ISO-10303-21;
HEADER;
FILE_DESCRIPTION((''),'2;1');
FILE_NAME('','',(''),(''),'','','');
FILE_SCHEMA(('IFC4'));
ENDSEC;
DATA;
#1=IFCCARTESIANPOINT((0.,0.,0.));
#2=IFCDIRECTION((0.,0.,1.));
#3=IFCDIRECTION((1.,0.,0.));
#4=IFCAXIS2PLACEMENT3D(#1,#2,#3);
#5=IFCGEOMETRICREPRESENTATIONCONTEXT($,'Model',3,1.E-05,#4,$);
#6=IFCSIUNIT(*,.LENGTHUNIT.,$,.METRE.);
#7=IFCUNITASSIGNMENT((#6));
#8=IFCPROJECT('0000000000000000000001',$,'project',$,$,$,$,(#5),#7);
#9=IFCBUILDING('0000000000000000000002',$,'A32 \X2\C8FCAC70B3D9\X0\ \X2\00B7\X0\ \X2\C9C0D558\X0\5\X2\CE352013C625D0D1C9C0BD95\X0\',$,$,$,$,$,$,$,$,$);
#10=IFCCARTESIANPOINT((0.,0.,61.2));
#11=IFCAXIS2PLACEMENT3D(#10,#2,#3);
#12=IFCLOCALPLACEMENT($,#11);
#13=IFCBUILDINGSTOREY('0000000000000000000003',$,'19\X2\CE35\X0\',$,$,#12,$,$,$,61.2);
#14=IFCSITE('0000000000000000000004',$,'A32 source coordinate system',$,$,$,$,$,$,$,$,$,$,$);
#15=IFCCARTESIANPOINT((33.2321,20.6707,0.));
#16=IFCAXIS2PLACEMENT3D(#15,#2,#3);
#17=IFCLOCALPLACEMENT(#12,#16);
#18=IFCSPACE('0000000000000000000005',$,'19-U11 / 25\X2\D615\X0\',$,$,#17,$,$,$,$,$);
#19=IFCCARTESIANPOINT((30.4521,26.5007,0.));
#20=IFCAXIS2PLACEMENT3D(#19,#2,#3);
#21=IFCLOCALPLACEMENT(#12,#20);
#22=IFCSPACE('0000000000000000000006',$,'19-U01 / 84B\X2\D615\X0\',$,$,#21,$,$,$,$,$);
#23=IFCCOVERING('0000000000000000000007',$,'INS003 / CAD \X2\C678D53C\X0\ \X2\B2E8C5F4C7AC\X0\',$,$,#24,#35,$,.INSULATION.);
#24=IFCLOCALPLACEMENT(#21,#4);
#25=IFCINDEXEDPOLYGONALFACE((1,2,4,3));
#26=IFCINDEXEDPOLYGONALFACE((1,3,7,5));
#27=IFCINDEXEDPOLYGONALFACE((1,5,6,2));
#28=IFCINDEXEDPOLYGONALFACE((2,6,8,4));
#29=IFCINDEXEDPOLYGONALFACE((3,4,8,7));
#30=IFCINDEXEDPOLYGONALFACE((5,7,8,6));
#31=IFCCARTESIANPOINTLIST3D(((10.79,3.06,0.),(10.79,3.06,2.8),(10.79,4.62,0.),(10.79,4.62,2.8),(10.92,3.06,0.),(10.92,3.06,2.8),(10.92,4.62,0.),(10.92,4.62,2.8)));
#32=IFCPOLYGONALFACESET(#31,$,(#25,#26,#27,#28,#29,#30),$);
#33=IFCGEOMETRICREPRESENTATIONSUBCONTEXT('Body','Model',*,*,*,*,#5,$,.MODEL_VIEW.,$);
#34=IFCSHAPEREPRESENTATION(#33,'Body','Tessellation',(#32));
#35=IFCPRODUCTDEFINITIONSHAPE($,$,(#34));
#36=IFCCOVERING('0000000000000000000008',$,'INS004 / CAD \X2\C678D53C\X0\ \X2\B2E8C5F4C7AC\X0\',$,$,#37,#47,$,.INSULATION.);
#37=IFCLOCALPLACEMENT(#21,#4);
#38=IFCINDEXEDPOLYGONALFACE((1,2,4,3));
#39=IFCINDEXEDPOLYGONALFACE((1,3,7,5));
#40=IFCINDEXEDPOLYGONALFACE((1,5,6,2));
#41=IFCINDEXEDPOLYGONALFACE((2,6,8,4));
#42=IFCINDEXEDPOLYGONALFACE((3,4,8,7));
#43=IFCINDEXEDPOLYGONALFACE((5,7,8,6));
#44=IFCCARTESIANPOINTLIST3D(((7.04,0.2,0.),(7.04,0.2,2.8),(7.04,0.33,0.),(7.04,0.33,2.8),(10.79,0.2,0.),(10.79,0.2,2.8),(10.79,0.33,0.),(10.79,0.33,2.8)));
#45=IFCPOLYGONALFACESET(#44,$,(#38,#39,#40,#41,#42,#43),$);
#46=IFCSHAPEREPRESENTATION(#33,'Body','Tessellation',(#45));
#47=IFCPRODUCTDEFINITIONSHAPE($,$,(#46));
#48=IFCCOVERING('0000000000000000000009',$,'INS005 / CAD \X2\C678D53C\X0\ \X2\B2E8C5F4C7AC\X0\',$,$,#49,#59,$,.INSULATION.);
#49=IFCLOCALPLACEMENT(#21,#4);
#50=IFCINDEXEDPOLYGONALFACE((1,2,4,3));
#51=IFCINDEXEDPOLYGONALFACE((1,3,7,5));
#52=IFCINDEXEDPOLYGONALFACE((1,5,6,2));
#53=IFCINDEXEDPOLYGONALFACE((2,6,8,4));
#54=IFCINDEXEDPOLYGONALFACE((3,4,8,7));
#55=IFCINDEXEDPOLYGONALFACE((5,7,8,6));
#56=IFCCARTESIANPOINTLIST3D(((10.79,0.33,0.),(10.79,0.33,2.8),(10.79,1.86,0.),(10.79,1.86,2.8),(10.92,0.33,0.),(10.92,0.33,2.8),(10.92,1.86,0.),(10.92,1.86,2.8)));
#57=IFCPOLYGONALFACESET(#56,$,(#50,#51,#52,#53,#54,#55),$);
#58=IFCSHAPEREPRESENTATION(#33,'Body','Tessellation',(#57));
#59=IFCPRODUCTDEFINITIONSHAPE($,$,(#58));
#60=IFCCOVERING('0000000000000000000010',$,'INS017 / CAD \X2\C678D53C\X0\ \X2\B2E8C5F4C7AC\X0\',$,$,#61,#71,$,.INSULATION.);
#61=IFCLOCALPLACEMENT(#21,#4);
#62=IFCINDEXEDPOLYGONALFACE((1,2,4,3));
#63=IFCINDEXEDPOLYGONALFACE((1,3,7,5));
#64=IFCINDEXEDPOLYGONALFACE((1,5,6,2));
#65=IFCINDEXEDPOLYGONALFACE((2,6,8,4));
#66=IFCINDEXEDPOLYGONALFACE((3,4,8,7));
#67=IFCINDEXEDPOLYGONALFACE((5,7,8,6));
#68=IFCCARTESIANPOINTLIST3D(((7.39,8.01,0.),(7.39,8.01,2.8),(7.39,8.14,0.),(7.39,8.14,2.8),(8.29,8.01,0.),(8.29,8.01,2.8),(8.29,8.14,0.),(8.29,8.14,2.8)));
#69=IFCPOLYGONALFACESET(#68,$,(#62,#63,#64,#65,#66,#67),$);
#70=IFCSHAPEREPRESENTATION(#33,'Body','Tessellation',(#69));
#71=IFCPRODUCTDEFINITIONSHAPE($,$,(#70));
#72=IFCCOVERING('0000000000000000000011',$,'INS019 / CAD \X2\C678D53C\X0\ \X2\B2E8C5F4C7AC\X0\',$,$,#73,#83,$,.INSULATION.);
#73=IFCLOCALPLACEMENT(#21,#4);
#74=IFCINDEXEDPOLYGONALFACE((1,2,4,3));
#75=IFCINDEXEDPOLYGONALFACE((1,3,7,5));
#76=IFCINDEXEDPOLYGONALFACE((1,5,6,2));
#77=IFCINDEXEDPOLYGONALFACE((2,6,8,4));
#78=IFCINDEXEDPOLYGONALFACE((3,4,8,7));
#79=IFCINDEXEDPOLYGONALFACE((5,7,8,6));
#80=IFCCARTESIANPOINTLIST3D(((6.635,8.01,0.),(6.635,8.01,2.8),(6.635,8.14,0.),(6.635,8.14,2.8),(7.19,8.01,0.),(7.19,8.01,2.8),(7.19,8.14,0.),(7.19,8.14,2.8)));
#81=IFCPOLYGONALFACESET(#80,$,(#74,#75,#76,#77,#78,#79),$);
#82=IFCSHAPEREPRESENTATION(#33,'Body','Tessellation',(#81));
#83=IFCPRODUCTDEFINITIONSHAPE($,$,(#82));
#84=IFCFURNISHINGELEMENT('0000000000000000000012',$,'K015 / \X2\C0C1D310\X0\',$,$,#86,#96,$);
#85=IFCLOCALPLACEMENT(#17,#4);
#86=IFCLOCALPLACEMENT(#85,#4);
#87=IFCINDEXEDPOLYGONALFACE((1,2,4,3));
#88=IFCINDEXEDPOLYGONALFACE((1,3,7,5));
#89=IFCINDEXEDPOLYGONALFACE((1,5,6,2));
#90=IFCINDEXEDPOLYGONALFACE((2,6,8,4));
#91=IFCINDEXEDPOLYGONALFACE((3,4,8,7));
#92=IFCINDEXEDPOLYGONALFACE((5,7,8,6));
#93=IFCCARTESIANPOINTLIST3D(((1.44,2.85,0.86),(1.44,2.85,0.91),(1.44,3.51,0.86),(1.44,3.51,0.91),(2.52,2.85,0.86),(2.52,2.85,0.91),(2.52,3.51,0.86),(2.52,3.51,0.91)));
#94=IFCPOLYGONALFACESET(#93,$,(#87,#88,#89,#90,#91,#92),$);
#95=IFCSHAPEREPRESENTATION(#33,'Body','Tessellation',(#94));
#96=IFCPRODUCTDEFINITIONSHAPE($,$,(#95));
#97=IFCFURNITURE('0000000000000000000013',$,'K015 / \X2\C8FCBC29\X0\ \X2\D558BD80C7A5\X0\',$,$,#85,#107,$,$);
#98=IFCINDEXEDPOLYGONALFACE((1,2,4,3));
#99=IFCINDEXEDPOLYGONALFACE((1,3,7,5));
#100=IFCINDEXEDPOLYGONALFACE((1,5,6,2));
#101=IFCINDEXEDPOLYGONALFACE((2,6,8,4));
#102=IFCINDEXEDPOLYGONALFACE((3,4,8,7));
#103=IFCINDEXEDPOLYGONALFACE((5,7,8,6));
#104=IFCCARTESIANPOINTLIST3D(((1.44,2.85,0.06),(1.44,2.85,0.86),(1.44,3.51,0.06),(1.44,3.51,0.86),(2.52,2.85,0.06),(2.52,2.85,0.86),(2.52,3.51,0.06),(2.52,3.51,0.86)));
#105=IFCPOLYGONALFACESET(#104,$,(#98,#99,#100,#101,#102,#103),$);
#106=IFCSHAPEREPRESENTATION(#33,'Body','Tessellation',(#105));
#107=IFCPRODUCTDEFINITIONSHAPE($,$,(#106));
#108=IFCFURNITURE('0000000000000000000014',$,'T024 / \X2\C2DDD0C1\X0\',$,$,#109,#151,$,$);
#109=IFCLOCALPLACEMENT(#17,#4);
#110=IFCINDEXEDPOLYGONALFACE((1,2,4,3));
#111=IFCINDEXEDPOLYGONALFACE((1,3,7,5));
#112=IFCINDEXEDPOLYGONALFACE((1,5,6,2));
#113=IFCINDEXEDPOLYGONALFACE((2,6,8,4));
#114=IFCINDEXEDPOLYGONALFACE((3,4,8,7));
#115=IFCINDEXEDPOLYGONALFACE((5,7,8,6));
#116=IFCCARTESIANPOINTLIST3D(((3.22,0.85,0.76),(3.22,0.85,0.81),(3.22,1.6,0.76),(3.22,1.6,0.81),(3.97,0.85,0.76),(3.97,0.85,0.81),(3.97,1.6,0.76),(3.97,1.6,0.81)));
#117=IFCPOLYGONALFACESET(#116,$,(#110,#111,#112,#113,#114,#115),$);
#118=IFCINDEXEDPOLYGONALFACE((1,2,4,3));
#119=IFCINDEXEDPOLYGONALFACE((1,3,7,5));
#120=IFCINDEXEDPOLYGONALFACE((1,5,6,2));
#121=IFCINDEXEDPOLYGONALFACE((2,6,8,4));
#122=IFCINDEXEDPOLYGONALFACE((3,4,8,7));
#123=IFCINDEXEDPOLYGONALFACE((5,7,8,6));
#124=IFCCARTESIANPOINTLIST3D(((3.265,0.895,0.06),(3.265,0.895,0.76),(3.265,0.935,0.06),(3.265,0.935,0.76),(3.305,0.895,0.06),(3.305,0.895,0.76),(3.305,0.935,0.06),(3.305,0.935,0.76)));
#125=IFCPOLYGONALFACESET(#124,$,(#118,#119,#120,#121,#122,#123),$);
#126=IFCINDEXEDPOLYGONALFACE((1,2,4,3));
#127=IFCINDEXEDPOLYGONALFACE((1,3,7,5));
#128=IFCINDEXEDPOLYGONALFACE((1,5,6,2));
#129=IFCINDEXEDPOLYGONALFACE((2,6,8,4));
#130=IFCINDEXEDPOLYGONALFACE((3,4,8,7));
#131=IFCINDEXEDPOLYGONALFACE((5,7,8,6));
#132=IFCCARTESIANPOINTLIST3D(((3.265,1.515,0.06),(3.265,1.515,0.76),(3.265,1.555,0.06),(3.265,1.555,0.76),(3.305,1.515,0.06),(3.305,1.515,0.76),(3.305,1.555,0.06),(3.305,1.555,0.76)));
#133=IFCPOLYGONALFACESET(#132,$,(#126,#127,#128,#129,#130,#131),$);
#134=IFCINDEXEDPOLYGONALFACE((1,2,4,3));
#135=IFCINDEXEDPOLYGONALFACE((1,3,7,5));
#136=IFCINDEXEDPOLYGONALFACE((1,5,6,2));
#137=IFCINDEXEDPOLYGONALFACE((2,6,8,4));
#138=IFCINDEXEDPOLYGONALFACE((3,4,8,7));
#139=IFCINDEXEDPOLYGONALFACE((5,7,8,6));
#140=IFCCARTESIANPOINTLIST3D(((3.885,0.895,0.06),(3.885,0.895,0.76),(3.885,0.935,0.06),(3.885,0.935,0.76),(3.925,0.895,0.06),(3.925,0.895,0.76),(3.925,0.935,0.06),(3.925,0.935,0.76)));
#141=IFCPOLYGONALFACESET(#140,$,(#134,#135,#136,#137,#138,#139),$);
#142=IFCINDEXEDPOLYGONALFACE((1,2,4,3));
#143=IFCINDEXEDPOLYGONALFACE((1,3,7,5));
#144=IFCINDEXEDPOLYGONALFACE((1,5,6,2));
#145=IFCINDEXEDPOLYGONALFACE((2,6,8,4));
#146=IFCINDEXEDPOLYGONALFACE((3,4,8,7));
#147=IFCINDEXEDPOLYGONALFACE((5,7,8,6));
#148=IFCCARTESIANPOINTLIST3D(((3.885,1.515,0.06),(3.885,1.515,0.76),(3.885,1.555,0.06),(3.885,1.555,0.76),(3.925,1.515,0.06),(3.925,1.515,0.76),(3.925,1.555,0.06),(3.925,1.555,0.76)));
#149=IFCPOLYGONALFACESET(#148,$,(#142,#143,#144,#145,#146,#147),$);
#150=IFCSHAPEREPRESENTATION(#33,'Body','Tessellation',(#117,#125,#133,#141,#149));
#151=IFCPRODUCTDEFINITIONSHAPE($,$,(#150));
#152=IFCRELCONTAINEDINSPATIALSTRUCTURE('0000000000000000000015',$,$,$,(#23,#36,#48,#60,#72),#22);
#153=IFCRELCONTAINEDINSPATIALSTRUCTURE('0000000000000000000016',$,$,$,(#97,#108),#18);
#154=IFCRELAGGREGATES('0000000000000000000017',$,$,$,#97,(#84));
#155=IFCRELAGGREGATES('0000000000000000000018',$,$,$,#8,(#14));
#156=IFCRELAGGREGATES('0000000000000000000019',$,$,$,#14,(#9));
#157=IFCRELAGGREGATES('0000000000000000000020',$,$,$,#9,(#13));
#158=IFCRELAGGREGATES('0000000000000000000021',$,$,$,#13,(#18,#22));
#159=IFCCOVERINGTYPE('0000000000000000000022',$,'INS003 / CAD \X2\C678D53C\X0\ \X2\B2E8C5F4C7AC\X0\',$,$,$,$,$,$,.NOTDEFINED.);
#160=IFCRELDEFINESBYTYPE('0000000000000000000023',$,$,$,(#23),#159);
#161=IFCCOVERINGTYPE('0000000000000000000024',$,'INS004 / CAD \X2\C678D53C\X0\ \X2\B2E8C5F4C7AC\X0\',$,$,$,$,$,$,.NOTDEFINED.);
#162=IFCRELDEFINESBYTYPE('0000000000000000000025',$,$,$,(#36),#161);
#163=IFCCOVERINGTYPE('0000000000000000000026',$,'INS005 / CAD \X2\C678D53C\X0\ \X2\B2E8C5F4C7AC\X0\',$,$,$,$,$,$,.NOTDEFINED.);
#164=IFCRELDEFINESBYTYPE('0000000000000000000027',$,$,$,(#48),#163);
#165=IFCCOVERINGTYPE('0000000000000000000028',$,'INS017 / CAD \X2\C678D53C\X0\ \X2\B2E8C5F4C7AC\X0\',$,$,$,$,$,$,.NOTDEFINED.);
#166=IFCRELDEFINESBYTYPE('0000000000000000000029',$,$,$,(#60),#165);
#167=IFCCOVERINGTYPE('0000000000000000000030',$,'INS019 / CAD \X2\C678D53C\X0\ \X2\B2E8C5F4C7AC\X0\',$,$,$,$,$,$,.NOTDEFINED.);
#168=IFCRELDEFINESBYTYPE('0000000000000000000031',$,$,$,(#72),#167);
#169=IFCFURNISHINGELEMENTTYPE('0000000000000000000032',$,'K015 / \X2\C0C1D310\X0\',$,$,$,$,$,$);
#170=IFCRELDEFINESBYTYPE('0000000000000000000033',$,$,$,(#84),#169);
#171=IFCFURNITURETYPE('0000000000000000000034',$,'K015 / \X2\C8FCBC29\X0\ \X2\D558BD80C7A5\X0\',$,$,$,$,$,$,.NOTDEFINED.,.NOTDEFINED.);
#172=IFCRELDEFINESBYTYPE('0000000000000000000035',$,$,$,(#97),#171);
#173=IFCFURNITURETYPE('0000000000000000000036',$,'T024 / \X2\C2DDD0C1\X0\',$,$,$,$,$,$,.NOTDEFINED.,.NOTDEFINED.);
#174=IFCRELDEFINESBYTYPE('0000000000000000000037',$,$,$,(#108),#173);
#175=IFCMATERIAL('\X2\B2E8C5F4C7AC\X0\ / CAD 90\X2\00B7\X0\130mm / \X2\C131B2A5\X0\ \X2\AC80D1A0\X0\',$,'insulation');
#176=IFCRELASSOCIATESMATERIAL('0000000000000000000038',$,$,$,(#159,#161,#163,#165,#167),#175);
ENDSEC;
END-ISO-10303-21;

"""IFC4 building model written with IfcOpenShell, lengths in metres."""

from ifc_helpers import new_model, si_unit, frame, origin, origin_with_axes, place, context, subcontext, project, spatial, polyline, outline, extrude, source, transform, mapped, material, type_object, type_shapes, element, aggregate, save


model = new_model("IFC4")

# Units and contexts
model_context = context("Model", 3, precision=1e-05, world=origin_with_axes())
body_context = subcontext(model_context, "Body", "Model", "MODEL_VIEW")
ifc_project = project(units=[si_unit("LENGTHUNIT", "METRE")], contexts=[model_context])

# Site, building, storey, space
site = spatial("IfcSite", under=ifc_project, Name="A32 source coordinate system")
building = spatial("IfcBuilding", under=site, Name="A32 주거동 · 지하5층–옥탑지붕")
storey_placement = place(None, frame((0.0, 0.0, 61.2), z_axis=(0.0, 0.0, 1.0), x_axis=(1.0, 0.0, 0.0)))
storey = spatial("IfcBuildingStorey", under=building, at=storey_placement, Name="19층", Elevation=61.2)
space_1_placement = place(storey_placement, frame((33.2321, 20.6707, 0.0), z_axis=(0.0, 0.0, 1.0), x_axis=(1.0, 0.0, 0.0)))
space_1 = spatial("IfcSpace", under=storey, at=space_1_placement, Name="19-U11 / 25형")

# Shared definitions
space_2_placement = place(storey_placement, frame((30.4521, 26.5007, 0.0), z_axis=(0.0, 0.0, 1.0), x_axis=(1.0, 0.0, 0.0)))
space_2 = spatial("IfcSpace", under=storey, at=space_2_placement, Name="19-U01 / 84B형")

# Coverings
ifc_material = material(Name="단열재 / CAD 90·130mm / 성능 검토", Category="insulation")
covering_type_1 = type_object("IfcCoveringType", Name="INS003 / CAD 외피 단열재", PredefinedType="NOTDEFINED", material=ifc_material)
shared_shape_1 = source(origin(), body_context, "Body", "SweptSolid", [
    extrude(outline(polyline([(10.79, 3.06), (10.79, 4.62), (10.92, 4.62), (10.92, 3.06), (10.79, 3.06)])), origin(), (0.0, 0.0, 1.0), 2.8),
])
type_shapes(covering_type_1, [shared_shape_1])
covering_1_placement = place(space_2_placement, origin_with_axes())
element("IfcCovering", 1, at=covering_1_placement, inside=space_2, type_object=covering_type_1, Name="INS003 / CAD 외피 단열재", PredefinedType="INSULATION", context=body_context, shape_type="MappedRepresentation", body=[
    mapped(shared_shape_1, transform((0.0, 0.0, 0.0), scale=1.0)),
])
covering_type_2 = type_object("IfcCoveringType", Name="INS004 / CAD 외피 단열재", PredefinedType="NOTDEFINED", material=ifc_material)
shared_shape_2 = source(origin(), body_context, "Body", "SweptSolid", [
    extrude(outline(polyline([(7.04, 0.33), (10.79, 0.33), (10.79, 0.2), (7.04, 0.2), (7.04, 0.33)])), origin(), (0.0, 0.0, 1.0), 2.8),
])
type_shapes(covering_type_2, [shared_shape_2])
covering_2_placement = place(space_2_placement, origin_with_axes())
element("IfcCovering", 2, at=covering_2_placement, inside=space_2, type_object=covering_type_2, Name="INS004 / CAD 외피 단열재", PredefinedType="INSULATION", context=body_context, shape_type="MappedRepresentation", body=[
    mapped(shared_shape_2, transform((0.0, 0.0, 0.0), scale=1.0)),
])
covering_type_3 = type_object("IfcCoveringType", Name="INS005 / CAD 외피 단열재", PredefinedType="NOTDEFINED", material=ifc_material)
shared_shape_3 = source(origin(), body_context, "Body", "SweptSolid", [
    extrude(outline(polyline([(10.79, 0.33), (10.79, 1.86), (10.92, 1.86), (10.92, 0.33), (10.79, 0.33)])), origin(), (0.0, 0.0, 1.0), 2.8),
])
type_shapes(covering_type_3, [shared_shape_3])
covering_3_placement = place(space_2_placement, origin_with_axes())
element("IfcCovering", 3, at=covering_3_placement, inside=space_2, type_object=covering_type_3, Name="INS005 / CAD 외피 단열재", PredefinedType="INSULATION", context=body_context, shape_type="MappedRepresentation", body=[
    mapped(shared_shape_3, transform((0.0, 0.0, 0.0), scale=1.0)),
])
covering_type_4 = type_object("IfcCoveringType", Name="INS017 / CAD 외피 단열재", PredefinedType="NOTDEFINED", material=ifc_material)
shared_shape_4 = source(origin(), body_context, "Body", "SweptSolid", [
    extrude(outline(polyline([(8.29, 8.01), (7.39, 8.01), (7.39, 8.14), (8.29, 8.14), (8.29, 8.01)])), origin(), (0.0, 0.0, 1.0), 2.8),
])
type_shapes(covering_type_4, [shared_shape_4])
covering_4_placement = place(space_2_placement, origin_with_axes())
element("IfcCovering", 4, at=covering_4_placement, inside=space_2, type_object=covering_type_4, Name="INS017 / CAD 외피 단열재", PredefinedType="INSULATION", context=body_context, shape_type="MappedRepresentation", body=[
    mapped(shared_shape_4, transform((0.0, 0.0, 0.0), scale=1.0)),
])
covering_type_5 = type_object("IfcCoveringType", Name="INS019 / CAD 외피 단열재", PredefinedType="NOTDEFINED", material=ifc_material)
shared_shape_5 = source(origin(), body_context, "Body", "SweptSolid", [
    extrude(outline(polyline([(6.635, 8.01), (6.635, 8.14), (7.19, 8.14), (7.19, 8.01), (6.635, 8.01)])), origin(), (0.0, 0.0, 1.0), 2.8),
])
type_shapes(covering_type_5, [shared_shape_5])
covering_5_placement = place(space_2_placement, origin_with_axes())
element("IfcCovering", 5, at=covering_5_placement, inside=space_2, type_object=covering_type_5, Name="INS019 / CAD 외피 단열재", PredefinedType="INSULATION", context=body_context, shape_type="MappedRepresentation", body=[
    mapped(shared_shape_5, transform((0.0, 0.0, 0.0), scale=1.0)),
])

# Furnishing element
furnishing_element_type_1 = type_object("IfcFurnishingElementType", Name="K015 / 상판")
shared_shape_6 = source(origin(), body_context, "Body", "SweptSolid", [
    extrude(outline(polyline([(2.52, 2.85), (1.44, 2.85), (1.44, 3.51), (2.52, 3.51), (2.52, 2.85)])), frame((0.0, 0.0, 0.86)), (0.0, 0.0, 1.0), 0.05),
])
type_shapes(furnishing_element_type_1, [shared_shape_6])
furniture_1_placement = place(space_1_placement, origin_with_axes())
furnishing_1_placement = place(furniture_1_placement, origin_with_axes())
furnishing_1 = element("IfcFurnishingElement", 6, at=furnishing_1_placement, type_object=furnishing_element_type_1, Name="K015 / 상판", context=body_context, shape_type="MappedRepresentation", body=[
    mapped(shared_shape_6, transform((0.0, 0.0, 0.0), scale=1.0)),
])

# Furniture
furniture_type_1 = type_object("IfcFurnitureType", Name="K015 / 주방 하부장", AssemblyPlace="NOTDEFINED", PredefinedType="NOTDEFINED")
shared_shape_7 = source(origin(), body_context, "Body", "SweptSolid", [
    extrude(outline(polyline([(2.52, 3.51), (2.52, 2.85), (1.44, 2.85), (1.44, 3.51), (2.52, 3.51)])), frame((0.0, 0.0, 0.06)), (0.0, 0.0, 1.0), 0.8),
])
type_shapes(furniture_type_1, [shared_shape_7])
furniture_1 = element("IfcFurniture", 7, at=furniture_1_placement, inside=space_1, type_object=furniture_type_1, Name="K015 / 주방 하부장", context=body_context, shape_type="MappedRepresentation", body=[
    mapped(shared_shape_7, transform((0.0, 0.0, 0.0), scale=1.0)),
])
aggregate(furniture_1, [furnishing_1])
furniture_type_2 = type_object("IfcFurnitureType", Name="T024 / 식탁", AssemblyPlace="NOTDEFINED", PredefinedType="NOTDEFINED")
shared_shape_8 = source(origin(), body_context, "Body", "SweptSolid", [
    extrude(outline(polyline([(3.22, 0.85), (3.22, 1.6), (3.97, 1.6), (3.97, 0.85), (3.22, 0.85)])), frame((0.0, 0.0, 0.76)), (0.0, 0.0, 1.0), 0.05),
    extrude(outline(polyline([(3.265, 0.895), (3.265, 0.935), (3.305, 0.935), (3.305, 0.895), (3.265, 0.895)])), frame((0.0, 0.0, 0.06)), (0.0, 0.0, 1.0), 0.7),
    extrude(outline(polyline([(3.265, 1.515), (3.265, 1.555), (3.305, 1.555), (3.305, 1.515), (3.265, 1.515)])), frame((0.0, 0.0, 0.06)), (0.0, 0.0, 1.0), 0.7),
    extrude(outline(polyline([(3.885, 0.895), (3.885, 0.935), (3.925, 0.935), (3.925, 0.895), (3.885, 0.895)])), frame((0.0, 0.0, 0.06)), (0.0, 0.0, 1.0), 0.7),
    extrude(outline(polyline([(3.885, 1.515), (3.885, 1.555), (3.925, 1.555), (3.925, 1.515), (3.885, 1.515)])), frame((0.0, 0.0, 0.06)), (0.0, 0.0, 1.0), 0.7),
])
type_shapes(furniture_type_2, [shared_shape_8])
furniture_2_placement = place(space_1_placement, origin_with_axes())
element("IfcFurniture", 8, at=furniture_2_placement, inside=space_1, type_object=furniture_type_2, Name="T024 / 식탁", context=body_context, shape_type="MappedRepresentation", body=[
    mapped(shared_shape_8, transform((0.0, 0.0, 0.0), scale=1.0)),
])

save(model, "model.ifc")
